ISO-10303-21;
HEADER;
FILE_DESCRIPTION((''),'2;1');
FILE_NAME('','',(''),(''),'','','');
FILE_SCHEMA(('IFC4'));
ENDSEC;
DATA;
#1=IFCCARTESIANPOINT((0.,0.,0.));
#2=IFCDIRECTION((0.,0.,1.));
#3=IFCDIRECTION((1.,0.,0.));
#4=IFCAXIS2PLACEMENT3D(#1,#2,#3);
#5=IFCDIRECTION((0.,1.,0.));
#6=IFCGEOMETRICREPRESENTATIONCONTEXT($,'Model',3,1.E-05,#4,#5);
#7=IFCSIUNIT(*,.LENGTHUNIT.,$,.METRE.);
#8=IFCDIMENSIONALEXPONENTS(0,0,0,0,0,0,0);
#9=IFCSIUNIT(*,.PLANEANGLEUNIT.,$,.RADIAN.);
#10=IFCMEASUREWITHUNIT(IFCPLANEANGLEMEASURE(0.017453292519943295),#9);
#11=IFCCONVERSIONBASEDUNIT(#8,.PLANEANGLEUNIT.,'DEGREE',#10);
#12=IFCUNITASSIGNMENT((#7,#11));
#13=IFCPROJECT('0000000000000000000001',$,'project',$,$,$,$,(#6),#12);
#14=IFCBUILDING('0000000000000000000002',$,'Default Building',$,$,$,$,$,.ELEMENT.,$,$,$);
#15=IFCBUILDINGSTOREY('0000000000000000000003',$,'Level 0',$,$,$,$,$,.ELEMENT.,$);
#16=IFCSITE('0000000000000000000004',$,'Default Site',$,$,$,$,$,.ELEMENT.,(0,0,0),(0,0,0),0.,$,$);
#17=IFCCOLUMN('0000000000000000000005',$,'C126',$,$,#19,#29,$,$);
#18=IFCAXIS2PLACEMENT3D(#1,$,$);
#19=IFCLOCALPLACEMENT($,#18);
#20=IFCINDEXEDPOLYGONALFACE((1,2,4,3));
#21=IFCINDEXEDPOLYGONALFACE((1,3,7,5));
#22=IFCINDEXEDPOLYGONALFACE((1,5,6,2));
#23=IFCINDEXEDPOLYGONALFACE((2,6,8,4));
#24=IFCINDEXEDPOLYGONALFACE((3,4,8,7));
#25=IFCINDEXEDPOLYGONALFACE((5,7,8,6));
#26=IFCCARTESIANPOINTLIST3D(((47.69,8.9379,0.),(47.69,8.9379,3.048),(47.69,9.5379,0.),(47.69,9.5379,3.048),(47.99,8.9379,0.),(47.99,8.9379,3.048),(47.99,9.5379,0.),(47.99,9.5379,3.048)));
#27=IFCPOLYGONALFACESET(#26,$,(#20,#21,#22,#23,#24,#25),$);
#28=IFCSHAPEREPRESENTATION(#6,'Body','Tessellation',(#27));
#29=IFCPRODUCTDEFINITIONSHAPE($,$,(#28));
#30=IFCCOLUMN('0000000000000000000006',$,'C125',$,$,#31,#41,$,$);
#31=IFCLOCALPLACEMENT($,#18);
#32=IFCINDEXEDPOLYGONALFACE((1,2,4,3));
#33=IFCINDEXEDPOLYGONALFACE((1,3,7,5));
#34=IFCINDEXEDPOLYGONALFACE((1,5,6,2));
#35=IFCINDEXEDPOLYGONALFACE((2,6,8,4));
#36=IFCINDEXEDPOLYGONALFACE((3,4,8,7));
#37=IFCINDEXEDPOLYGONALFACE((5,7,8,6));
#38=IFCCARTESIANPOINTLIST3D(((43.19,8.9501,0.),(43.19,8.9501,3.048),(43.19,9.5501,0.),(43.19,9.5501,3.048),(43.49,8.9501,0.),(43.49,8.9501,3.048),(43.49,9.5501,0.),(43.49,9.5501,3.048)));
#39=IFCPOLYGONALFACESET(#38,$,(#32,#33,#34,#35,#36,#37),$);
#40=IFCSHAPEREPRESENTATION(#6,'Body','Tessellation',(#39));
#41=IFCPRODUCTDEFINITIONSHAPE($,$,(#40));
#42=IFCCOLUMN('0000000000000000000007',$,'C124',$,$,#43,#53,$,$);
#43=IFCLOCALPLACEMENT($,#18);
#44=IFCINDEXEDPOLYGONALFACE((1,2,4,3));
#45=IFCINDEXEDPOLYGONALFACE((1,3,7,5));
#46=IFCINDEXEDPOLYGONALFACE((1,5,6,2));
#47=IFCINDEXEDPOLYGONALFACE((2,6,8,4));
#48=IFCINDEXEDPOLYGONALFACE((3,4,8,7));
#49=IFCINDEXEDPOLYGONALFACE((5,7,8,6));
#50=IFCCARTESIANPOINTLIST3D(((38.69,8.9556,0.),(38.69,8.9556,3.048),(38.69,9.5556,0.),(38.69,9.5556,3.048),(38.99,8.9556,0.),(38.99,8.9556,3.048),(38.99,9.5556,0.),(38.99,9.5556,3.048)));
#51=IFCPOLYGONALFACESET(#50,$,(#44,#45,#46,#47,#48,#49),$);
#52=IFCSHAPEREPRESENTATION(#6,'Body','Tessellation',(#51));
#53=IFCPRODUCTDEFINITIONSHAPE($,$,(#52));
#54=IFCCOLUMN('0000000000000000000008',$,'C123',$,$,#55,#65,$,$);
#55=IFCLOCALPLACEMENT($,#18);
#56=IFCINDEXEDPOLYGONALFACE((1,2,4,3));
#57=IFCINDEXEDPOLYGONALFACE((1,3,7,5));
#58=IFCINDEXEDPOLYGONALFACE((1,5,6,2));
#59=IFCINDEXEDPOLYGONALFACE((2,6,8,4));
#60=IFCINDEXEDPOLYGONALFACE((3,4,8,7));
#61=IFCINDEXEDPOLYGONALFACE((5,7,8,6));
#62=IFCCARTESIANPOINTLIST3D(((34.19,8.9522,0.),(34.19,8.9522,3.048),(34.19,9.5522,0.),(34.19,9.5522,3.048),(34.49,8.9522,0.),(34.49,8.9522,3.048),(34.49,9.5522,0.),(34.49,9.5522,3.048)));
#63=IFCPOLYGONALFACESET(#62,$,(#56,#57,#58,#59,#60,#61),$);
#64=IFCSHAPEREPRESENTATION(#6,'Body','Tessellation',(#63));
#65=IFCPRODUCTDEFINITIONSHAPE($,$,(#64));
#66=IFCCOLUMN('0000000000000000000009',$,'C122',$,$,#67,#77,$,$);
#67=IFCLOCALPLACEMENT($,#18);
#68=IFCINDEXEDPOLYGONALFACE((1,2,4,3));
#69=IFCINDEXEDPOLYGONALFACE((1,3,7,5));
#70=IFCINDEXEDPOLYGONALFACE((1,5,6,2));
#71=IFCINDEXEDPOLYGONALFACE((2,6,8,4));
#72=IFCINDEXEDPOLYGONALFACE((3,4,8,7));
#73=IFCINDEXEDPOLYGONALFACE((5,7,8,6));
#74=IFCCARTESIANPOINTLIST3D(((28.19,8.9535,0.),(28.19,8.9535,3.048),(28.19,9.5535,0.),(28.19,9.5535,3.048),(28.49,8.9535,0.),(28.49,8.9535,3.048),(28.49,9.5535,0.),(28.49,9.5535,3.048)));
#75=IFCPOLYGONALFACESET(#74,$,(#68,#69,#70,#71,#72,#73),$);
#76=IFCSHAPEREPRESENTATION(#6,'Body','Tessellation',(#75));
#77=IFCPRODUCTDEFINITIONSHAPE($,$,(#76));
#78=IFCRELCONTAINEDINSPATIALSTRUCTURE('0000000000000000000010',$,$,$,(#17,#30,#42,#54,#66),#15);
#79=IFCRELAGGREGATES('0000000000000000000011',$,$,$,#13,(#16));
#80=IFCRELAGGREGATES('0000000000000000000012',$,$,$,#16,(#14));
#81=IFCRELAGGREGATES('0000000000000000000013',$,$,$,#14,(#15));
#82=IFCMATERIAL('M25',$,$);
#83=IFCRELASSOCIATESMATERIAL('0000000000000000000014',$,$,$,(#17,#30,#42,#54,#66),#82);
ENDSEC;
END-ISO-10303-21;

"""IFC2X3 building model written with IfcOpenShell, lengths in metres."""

from ifc_helpers import new_model, entity, si_unit, converted_unit, direction, frame, frame_2d, origin_with_axes, place, context, project, spatial, rectangle, extrude, material, element, save


model = new_model("IFC2X3")

# Units and contexts
model_context = context("Model", 3, precision=1e-05, world=origin_with_axes(), true_north=direction((0.0, 1.0, 0.0)))
ifc_project = project(units=[si_unit("LENGTHUNIT", "METRE"), converted_unit("PLANEANGLEUNIT", "DEGREE", entity("IfcPlaneAngleMeasure", 0.017453292519943295), si_unit("PLANEANGLEUNIT", "RADIAN"), dimensions=[0, 0, 0, 0, 0, 0, 0])], contexts=[model_context])

# Site, building, storey
site = spatial("IfcSite", under=ifc_project, Name="Default Site", CompositionType="ELEMENT", RefLatitude=(0, 0, 0), RefLongitude=(0, 0, 0), RefElevation=0.0)
building = spatial("IfcBuilding", under=site, Name="Default Building", CompositionType="ELEMENT")
storey = spatial("IfcBuildingStorey", under=building, Name="Level 0", CompositionType="ELEMENT")

# Columns
ifc_material = material(Name="M25")
placement = place(None, origin_with_axes())
element("IfcColumn", 1, at=placement, inside=storey, material=ifc_material, Name="C126", context=model_context, shape_type="SweptSolid", body=[
    extrude(rectangle(XDim=0.3, YDim=0.6, at=frame_2d((0.0, 0.0), x_axis=(1.0, 0.0, 0.0))), frame((47.84, 9.2379, 0.0), z_axis=(0.0, 0.0, 1.0), x_axis=(1.0, 0.0, 0.0)), (0.0, 0.0, 1.0), 3.048),
])
element("IfcColumn", 2, at=placement, inside=storey, material=ifc_material, Name="C125", context=model_context, shape_type="SweptSolid", body=[
    extrude(rectangle(XDim=0.3, YDim=0.6, at=frame_2d((0.0, 0.0), x_axis=(1.0, 0.0, 0.0))), frame((43.34, 9.2501, 0.0), z_axis=(0.0, 0.0, 1.0), x_axis=(1.0, 0.0, 0.0)), (0.0, 0.0, 1.0), 3.048),
])
element("IfcColumn", 3, at=placement, inside=storey, material=ifc_material, Name="C124", context=model_context, shape_type="SweptSolid", body=[
    extrude(rectangle(XDim=0.3, YDim=0.6, at=frame_2d((0.0, 0.0), x_axis=(1.0, 0.0, 0.0))), frame((38.84, 9.2556, 0.0), z_axis=(0.0, 0.0, 1.0), x_axis=(1.0, 0.0, 0.0)), (0.0, 0.0, 1.0), 3.048),
])
element("IfcColumn", 4, at=placement, inside=storey, material=ifc_material, Name="C123", context=model_context, shape_type="SweptSolid", body=[
    extrude(rectangle(XDim=0.3, YDim=0.6, at=frame_2d((0.0, 0.0), x_axis=(1.0, 0.0, 0.0))), frame((34.34, 9.2522, 0.0), z_axis=(0.0, 0.0, 1.0), x_axis=(1.0, 0.0, 0.0)), (0.0, 0.0, 1.0), 3.048),
])
element("IfcColumn", 5, at=placement, inside=storey, material=ifc_material, Name="C122", context=model_context, shape_type="SweptSolid", body=[
    extrude(rectangle(XDim=0.3, YDim=0.6, at=frame_2d((0.0, 0.0), x_axis=(1.0, 0.0, 0.0))), frame((28.34, 9.2535, 0.0), z_axis=(0.0, 0.0, 1.0), x_axis=(1.0, 0.0, 0.0)), (0.0, 0.0, 1.0), 3.048),
])

save(model, "model.ifc")
